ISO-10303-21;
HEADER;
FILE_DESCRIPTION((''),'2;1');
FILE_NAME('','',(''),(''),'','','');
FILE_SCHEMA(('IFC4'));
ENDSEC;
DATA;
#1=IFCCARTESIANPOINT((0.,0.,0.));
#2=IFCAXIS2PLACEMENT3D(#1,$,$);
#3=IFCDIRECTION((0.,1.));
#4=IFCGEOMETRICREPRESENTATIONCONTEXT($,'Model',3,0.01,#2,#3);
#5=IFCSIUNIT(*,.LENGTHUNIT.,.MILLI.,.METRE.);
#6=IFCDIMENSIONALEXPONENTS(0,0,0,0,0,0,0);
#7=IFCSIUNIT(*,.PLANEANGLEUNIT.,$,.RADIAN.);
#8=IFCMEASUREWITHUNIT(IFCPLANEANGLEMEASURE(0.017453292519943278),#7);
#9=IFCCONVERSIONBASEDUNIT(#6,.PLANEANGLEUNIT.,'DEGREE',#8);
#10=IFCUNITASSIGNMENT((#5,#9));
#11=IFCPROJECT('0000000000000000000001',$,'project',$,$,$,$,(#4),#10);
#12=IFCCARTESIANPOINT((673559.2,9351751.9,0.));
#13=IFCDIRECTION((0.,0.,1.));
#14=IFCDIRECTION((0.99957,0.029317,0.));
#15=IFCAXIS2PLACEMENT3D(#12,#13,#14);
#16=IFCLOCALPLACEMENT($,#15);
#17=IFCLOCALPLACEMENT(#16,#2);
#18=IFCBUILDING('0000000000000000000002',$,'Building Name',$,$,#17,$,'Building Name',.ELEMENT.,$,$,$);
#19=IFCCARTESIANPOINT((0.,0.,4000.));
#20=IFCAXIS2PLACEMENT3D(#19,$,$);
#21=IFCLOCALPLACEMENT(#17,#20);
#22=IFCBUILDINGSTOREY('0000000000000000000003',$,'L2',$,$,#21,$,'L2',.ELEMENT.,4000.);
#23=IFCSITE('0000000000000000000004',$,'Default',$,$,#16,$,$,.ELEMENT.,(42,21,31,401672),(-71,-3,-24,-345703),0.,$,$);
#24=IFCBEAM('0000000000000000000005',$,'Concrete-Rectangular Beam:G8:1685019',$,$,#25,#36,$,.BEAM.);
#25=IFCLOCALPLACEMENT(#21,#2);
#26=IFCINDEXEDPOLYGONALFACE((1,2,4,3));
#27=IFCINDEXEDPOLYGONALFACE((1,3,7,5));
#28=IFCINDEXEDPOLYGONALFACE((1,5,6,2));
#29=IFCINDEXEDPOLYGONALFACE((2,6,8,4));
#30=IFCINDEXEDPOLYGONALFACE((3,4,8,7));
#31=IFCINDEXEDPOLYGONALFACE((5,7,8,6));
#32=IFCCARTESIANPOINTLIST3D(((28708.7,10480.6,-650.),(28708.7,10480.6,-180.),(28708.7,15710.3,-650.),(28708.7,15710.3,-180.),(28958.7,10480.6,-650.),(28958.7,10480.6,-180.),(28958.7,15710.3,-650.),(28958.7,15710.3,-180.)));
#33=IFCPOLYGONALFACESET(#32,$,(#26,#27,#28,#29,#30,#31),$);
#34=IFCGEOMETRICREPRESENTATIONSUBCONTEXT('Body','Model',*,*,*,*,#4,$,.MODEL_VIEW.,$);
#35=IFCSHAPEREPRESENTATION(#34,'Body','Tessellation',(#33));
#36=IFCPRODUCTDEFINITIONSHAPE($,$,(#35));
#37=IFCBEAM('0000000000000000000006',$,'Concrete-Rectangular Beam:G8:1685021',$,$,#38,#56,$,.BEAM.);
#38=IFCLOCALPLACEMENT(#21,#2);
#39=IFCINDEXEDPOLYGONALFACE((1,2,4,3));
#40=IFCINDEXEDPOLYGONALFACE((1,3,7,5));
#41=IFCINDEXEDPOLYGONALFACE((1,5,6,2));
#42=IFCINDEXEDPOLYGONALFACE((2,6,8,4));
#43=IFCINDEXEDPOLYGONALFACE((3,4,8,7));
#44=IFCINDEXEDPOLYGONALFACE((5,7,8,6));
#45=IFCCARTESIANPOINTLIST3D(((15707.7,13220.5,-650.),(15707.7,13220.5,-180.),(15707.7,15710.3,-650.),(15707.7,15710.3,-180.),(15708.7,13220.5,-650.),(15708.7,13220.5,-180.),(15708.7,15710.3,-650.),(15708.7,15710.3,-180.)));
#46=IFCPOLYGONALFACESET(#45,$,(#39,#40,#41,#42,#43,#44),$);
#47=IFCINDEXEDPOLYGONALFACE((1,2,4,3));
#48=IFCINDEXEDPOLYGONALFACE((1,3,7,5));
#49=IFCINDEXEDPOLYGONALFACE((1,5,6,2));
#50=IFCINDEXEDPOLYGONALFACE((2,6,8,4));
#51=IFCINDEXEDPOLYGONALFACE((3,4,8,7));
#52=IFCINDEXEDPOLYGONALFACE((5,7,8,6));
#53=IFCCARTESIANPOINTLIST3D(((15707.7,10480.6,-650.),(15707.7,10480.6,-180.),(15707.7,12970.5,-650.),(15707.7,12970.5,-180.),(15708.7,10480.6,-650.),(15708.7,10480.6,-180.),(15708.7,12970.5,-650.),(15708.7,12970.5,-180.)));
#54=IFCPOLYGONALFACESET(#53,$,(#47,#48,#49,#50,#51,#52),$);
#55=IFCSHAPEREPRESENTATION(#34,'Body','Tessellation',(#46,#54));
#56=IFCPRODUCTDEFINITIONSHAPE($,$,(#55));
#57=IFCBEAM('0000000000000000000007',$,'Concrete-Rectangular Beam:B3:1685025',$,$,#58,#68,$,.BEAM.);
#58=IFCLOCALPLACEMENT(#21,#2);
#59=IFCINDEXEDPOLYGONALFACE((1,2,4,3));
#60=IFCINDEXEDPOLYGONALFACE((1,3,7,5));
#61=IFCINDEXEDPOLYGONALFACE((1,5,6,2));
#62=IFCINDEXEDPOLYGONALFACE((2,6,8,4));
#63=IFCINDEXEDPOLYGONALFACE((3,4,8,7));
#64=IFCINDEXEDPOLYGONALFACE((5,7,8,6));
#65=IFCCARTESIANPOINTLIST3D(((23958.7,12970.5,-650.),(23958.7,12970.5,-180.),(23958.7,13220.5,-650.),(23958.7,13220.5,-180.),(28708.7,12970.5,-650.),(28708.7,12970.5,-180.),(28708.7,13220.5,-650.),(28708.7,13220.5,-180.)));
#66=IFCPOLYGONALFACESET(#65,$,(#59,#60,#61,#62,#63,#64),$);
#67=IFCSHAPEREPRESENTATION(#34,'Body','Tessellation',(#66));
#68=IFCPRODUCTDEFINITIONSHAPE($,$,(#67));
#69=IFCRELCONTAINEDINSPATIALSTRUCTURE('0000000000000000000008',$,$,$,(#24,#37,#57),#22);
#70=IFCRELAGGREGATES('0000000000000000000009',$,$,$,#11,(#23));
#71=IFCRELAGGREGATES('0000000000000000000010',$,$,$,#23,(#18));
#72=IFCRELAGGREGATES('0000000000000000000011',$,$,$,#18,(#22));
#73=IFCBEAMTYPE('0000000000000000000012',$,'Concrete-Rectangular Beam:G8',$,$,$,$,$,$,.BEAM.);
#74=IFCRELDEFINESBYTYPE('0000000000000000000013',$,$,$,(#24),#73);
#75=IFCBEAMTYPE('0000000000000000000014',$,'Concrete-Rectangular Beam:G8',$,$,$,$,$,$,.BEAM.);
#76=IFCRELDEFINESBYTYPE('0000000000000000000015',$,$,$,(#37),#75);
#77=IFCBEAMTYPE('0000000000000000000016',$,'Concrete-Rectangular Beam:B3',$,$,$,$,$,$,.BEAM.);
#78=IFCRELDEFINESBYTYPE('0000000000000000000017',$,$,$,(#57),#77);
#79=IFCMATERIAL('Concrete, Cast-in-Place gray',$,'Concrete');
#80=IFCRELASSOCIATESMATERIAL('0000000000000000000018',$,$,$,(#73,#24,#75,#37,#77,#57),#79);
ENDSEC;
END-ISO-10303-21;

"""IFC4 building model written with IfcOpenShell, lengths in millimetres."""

from ifc_helpers import new_model, entity, si_unit, converted_unit, direction, frame, origin, place, context, subcontext, project, spatial, indexed_curve, outline, extrude, source, transform, mapped, material, type_object, type_shapes, element, save


model = new_model("IFC4")

# Units and contexts
model_context = context("Model", 3, precision=0.01, world=origin(), true_north=direction((0.0, 1.0)))
body_context = subcontext(model_context, "Body", "Model", "MODEL_VIEW")
ifc_project = project(units=[si_unit("LENGTHUNIT", "METRE", prefix="MILLI"), converted_unit("PLANEANGLEUNIT", "DEGREE", entity("IfcPlaneAngleMeasure", 0.017453292519943278), si_unit("PLANEANGLEUNIT", "RADIAN"), dimensions=[0, 0, 0, 0, 0, 0, 0])], contexts=[model_context])

# Site, building, storey
site_placement = place(None, frame((673559.2, 9351751.9, 0.0), z_axis=(0.0, 0.0, 1.0), x_axis=(0.99957, 0.029317, 0.0)))
site = spatial("IfcSite", under=ifc_project, at=site_placement, Name="Default", CompositionType="ELEMENT", RefLatitude=(42, 21, 31, 401672), RefLongitude=(-71, -3, -24, -345703), RefElevation=0.0)
building_placement = place(site_placement, origin())
building = spatial("IfcBuilding", under=site, at=building_placement, Name="Building Name", LongName="Building Name", CompositionType="ELEMENT")
storey_placement = place(building_placement, frame((0.0, 0.0, 4000.0)))
storey = spatial("IfcBuildingStorey", under=building, at=storey_placement, Name="L2", LongName="L2", CompositionType="ELEMENT", Elevation=4000.0)

# Shared definitions
ifc_material = material(Name="Concrete, Cast-in-Place gray", Category="Concrete")

# Beams
beam_type_1 = type_object("IfcBeamType", Name="Concrete-Rectangular Beam:G8", PredefinedType="BEAM", material=ifc_material)
shared_shape_1 = source(origin(), body_context, "Body", "SweptSolid", [
    extrude(outline(indexed_curve([(-125.0, -235.0), (125.0, -235.0), (125.0, 235.0), (-125.0, 235.0), (-125.0, -235.0)], self_intersect=False)), frame((28833.7, 10480.6, 3585.0), z_axis=(0.0, 1.0, 0.0), x_axis=(-1.0, 0.0, 0.0)), (0.0, 0.0, 1.0), 5229.7),
])
type_shapes(beam_type_1, [shared_shape_1])
beam_1_placement = place(storey_placement, frame((0.0, 0.0, -4000.0)))
element("IfcBeam", 1, at=beam_1_placement, inside=storey, type_object=beam_type_1, material=ifc_material, Name="Concrete-Rectangular Beam:G8:1685019", PredefinedType="BEAM", context=body_context, shape_type="MappedRepresentation", body=[
    mapped(shared_shape_1, transform((0.0, 0.0, 0.0), scale=1.0)),
])
beam_type_2 = type_object("IfcBeamType", Name="Concrete-Rectangular Beam:G8", PredefinedType="BEAM", material=ifc_material)
shared_shape_2 = source(origin(), body_context, "Body", "SweptSolid", [
    extrude(outline(indexed_curve([(-0.5, -235.0), (0.5, -235.0), (0.5, 235.0), (-0.5, 235.0), (-0.5, -235.0)], self_intersect=False)), frame((15708.2, 13220.5, 3585.0), z_axis=(0.0, 1.0, 0.0), x_axis=(-1.0, 0.0, 0.0)), (0.0, 0.0, 1.0), 2489.8),
    extrude(outline(indexed_curve([(-0.5, -235.0), (0.5, -235.0), (0.5, 235.0), (-0.5, 235.0), (-0.5, -235.0)], self_intersect=False)), frame((15708.2, 10480.6, 3585.0), z_axis=(0.0, 1.0, 0.0), x_axis=(-1.0, 0.0, 0.0)), (0.0, 0.0, 1.0), 2489.9),
])
type_shapes(beam_type_2, [shared_shape_2])
beam_2_placement = place(storey_placement, frame((0.0, 0.0, -4000.0)))
element("IfcBeam", 2, at=beam_2_placement, inside=storey, type_object=beam_type_2, material=ifc_material, Name="Concrete-Rectangular Beam:G8:1685021", PredefinedType="BEAM", context=body_context, shape_type="MappedRepresentation", body=[
    mapped(shared_shape_2, transform((0.0, 0.0, 0.0), scale=1.0)),
])
beam_type_3 = type_object("IfcBeamType", Name="Concrete-Rectangular Beam:B3", PredefinedType="BEAM", material=ifc_material)
shared_shape_3 = source(origin(), body_context, "Body", "SweptSolid", [
    extrude(outline(indexed_curve([(-235.0, -125.0), (235.0, -125.0), (235.0, 125.0), (-235.0, 125.0), (-235.0, -125.0)], self_intersect=False)), frame((23958.7, 13095.5, 3585.0), z_axis=(1.0, 0.0, 0.0), x_axis=(0.0, 0.0, -1.0)), (0.0, 0.0, 1.0), 4750.0),
])
type_shapes(beam_type_3, [shared_shape_3])
beam_3_placement = place(storey_placement, frame((0.0, 0.0, -4000.0)))
element("IfcBeam", 3, at=beam_3_placement, inside=storey, type_object=beam_type_3, material=ifc_material, Name="Concrete-Rectangular Beam:B3:1685025", PredefinedType="BEAM", context=body_context, shape_type="MappedRepresentation", body=[
    mapped(shared_shape_3, transform((0.0, 0.0, 0.0), scale=1.0)),
])

save(model, "model.ifc")
